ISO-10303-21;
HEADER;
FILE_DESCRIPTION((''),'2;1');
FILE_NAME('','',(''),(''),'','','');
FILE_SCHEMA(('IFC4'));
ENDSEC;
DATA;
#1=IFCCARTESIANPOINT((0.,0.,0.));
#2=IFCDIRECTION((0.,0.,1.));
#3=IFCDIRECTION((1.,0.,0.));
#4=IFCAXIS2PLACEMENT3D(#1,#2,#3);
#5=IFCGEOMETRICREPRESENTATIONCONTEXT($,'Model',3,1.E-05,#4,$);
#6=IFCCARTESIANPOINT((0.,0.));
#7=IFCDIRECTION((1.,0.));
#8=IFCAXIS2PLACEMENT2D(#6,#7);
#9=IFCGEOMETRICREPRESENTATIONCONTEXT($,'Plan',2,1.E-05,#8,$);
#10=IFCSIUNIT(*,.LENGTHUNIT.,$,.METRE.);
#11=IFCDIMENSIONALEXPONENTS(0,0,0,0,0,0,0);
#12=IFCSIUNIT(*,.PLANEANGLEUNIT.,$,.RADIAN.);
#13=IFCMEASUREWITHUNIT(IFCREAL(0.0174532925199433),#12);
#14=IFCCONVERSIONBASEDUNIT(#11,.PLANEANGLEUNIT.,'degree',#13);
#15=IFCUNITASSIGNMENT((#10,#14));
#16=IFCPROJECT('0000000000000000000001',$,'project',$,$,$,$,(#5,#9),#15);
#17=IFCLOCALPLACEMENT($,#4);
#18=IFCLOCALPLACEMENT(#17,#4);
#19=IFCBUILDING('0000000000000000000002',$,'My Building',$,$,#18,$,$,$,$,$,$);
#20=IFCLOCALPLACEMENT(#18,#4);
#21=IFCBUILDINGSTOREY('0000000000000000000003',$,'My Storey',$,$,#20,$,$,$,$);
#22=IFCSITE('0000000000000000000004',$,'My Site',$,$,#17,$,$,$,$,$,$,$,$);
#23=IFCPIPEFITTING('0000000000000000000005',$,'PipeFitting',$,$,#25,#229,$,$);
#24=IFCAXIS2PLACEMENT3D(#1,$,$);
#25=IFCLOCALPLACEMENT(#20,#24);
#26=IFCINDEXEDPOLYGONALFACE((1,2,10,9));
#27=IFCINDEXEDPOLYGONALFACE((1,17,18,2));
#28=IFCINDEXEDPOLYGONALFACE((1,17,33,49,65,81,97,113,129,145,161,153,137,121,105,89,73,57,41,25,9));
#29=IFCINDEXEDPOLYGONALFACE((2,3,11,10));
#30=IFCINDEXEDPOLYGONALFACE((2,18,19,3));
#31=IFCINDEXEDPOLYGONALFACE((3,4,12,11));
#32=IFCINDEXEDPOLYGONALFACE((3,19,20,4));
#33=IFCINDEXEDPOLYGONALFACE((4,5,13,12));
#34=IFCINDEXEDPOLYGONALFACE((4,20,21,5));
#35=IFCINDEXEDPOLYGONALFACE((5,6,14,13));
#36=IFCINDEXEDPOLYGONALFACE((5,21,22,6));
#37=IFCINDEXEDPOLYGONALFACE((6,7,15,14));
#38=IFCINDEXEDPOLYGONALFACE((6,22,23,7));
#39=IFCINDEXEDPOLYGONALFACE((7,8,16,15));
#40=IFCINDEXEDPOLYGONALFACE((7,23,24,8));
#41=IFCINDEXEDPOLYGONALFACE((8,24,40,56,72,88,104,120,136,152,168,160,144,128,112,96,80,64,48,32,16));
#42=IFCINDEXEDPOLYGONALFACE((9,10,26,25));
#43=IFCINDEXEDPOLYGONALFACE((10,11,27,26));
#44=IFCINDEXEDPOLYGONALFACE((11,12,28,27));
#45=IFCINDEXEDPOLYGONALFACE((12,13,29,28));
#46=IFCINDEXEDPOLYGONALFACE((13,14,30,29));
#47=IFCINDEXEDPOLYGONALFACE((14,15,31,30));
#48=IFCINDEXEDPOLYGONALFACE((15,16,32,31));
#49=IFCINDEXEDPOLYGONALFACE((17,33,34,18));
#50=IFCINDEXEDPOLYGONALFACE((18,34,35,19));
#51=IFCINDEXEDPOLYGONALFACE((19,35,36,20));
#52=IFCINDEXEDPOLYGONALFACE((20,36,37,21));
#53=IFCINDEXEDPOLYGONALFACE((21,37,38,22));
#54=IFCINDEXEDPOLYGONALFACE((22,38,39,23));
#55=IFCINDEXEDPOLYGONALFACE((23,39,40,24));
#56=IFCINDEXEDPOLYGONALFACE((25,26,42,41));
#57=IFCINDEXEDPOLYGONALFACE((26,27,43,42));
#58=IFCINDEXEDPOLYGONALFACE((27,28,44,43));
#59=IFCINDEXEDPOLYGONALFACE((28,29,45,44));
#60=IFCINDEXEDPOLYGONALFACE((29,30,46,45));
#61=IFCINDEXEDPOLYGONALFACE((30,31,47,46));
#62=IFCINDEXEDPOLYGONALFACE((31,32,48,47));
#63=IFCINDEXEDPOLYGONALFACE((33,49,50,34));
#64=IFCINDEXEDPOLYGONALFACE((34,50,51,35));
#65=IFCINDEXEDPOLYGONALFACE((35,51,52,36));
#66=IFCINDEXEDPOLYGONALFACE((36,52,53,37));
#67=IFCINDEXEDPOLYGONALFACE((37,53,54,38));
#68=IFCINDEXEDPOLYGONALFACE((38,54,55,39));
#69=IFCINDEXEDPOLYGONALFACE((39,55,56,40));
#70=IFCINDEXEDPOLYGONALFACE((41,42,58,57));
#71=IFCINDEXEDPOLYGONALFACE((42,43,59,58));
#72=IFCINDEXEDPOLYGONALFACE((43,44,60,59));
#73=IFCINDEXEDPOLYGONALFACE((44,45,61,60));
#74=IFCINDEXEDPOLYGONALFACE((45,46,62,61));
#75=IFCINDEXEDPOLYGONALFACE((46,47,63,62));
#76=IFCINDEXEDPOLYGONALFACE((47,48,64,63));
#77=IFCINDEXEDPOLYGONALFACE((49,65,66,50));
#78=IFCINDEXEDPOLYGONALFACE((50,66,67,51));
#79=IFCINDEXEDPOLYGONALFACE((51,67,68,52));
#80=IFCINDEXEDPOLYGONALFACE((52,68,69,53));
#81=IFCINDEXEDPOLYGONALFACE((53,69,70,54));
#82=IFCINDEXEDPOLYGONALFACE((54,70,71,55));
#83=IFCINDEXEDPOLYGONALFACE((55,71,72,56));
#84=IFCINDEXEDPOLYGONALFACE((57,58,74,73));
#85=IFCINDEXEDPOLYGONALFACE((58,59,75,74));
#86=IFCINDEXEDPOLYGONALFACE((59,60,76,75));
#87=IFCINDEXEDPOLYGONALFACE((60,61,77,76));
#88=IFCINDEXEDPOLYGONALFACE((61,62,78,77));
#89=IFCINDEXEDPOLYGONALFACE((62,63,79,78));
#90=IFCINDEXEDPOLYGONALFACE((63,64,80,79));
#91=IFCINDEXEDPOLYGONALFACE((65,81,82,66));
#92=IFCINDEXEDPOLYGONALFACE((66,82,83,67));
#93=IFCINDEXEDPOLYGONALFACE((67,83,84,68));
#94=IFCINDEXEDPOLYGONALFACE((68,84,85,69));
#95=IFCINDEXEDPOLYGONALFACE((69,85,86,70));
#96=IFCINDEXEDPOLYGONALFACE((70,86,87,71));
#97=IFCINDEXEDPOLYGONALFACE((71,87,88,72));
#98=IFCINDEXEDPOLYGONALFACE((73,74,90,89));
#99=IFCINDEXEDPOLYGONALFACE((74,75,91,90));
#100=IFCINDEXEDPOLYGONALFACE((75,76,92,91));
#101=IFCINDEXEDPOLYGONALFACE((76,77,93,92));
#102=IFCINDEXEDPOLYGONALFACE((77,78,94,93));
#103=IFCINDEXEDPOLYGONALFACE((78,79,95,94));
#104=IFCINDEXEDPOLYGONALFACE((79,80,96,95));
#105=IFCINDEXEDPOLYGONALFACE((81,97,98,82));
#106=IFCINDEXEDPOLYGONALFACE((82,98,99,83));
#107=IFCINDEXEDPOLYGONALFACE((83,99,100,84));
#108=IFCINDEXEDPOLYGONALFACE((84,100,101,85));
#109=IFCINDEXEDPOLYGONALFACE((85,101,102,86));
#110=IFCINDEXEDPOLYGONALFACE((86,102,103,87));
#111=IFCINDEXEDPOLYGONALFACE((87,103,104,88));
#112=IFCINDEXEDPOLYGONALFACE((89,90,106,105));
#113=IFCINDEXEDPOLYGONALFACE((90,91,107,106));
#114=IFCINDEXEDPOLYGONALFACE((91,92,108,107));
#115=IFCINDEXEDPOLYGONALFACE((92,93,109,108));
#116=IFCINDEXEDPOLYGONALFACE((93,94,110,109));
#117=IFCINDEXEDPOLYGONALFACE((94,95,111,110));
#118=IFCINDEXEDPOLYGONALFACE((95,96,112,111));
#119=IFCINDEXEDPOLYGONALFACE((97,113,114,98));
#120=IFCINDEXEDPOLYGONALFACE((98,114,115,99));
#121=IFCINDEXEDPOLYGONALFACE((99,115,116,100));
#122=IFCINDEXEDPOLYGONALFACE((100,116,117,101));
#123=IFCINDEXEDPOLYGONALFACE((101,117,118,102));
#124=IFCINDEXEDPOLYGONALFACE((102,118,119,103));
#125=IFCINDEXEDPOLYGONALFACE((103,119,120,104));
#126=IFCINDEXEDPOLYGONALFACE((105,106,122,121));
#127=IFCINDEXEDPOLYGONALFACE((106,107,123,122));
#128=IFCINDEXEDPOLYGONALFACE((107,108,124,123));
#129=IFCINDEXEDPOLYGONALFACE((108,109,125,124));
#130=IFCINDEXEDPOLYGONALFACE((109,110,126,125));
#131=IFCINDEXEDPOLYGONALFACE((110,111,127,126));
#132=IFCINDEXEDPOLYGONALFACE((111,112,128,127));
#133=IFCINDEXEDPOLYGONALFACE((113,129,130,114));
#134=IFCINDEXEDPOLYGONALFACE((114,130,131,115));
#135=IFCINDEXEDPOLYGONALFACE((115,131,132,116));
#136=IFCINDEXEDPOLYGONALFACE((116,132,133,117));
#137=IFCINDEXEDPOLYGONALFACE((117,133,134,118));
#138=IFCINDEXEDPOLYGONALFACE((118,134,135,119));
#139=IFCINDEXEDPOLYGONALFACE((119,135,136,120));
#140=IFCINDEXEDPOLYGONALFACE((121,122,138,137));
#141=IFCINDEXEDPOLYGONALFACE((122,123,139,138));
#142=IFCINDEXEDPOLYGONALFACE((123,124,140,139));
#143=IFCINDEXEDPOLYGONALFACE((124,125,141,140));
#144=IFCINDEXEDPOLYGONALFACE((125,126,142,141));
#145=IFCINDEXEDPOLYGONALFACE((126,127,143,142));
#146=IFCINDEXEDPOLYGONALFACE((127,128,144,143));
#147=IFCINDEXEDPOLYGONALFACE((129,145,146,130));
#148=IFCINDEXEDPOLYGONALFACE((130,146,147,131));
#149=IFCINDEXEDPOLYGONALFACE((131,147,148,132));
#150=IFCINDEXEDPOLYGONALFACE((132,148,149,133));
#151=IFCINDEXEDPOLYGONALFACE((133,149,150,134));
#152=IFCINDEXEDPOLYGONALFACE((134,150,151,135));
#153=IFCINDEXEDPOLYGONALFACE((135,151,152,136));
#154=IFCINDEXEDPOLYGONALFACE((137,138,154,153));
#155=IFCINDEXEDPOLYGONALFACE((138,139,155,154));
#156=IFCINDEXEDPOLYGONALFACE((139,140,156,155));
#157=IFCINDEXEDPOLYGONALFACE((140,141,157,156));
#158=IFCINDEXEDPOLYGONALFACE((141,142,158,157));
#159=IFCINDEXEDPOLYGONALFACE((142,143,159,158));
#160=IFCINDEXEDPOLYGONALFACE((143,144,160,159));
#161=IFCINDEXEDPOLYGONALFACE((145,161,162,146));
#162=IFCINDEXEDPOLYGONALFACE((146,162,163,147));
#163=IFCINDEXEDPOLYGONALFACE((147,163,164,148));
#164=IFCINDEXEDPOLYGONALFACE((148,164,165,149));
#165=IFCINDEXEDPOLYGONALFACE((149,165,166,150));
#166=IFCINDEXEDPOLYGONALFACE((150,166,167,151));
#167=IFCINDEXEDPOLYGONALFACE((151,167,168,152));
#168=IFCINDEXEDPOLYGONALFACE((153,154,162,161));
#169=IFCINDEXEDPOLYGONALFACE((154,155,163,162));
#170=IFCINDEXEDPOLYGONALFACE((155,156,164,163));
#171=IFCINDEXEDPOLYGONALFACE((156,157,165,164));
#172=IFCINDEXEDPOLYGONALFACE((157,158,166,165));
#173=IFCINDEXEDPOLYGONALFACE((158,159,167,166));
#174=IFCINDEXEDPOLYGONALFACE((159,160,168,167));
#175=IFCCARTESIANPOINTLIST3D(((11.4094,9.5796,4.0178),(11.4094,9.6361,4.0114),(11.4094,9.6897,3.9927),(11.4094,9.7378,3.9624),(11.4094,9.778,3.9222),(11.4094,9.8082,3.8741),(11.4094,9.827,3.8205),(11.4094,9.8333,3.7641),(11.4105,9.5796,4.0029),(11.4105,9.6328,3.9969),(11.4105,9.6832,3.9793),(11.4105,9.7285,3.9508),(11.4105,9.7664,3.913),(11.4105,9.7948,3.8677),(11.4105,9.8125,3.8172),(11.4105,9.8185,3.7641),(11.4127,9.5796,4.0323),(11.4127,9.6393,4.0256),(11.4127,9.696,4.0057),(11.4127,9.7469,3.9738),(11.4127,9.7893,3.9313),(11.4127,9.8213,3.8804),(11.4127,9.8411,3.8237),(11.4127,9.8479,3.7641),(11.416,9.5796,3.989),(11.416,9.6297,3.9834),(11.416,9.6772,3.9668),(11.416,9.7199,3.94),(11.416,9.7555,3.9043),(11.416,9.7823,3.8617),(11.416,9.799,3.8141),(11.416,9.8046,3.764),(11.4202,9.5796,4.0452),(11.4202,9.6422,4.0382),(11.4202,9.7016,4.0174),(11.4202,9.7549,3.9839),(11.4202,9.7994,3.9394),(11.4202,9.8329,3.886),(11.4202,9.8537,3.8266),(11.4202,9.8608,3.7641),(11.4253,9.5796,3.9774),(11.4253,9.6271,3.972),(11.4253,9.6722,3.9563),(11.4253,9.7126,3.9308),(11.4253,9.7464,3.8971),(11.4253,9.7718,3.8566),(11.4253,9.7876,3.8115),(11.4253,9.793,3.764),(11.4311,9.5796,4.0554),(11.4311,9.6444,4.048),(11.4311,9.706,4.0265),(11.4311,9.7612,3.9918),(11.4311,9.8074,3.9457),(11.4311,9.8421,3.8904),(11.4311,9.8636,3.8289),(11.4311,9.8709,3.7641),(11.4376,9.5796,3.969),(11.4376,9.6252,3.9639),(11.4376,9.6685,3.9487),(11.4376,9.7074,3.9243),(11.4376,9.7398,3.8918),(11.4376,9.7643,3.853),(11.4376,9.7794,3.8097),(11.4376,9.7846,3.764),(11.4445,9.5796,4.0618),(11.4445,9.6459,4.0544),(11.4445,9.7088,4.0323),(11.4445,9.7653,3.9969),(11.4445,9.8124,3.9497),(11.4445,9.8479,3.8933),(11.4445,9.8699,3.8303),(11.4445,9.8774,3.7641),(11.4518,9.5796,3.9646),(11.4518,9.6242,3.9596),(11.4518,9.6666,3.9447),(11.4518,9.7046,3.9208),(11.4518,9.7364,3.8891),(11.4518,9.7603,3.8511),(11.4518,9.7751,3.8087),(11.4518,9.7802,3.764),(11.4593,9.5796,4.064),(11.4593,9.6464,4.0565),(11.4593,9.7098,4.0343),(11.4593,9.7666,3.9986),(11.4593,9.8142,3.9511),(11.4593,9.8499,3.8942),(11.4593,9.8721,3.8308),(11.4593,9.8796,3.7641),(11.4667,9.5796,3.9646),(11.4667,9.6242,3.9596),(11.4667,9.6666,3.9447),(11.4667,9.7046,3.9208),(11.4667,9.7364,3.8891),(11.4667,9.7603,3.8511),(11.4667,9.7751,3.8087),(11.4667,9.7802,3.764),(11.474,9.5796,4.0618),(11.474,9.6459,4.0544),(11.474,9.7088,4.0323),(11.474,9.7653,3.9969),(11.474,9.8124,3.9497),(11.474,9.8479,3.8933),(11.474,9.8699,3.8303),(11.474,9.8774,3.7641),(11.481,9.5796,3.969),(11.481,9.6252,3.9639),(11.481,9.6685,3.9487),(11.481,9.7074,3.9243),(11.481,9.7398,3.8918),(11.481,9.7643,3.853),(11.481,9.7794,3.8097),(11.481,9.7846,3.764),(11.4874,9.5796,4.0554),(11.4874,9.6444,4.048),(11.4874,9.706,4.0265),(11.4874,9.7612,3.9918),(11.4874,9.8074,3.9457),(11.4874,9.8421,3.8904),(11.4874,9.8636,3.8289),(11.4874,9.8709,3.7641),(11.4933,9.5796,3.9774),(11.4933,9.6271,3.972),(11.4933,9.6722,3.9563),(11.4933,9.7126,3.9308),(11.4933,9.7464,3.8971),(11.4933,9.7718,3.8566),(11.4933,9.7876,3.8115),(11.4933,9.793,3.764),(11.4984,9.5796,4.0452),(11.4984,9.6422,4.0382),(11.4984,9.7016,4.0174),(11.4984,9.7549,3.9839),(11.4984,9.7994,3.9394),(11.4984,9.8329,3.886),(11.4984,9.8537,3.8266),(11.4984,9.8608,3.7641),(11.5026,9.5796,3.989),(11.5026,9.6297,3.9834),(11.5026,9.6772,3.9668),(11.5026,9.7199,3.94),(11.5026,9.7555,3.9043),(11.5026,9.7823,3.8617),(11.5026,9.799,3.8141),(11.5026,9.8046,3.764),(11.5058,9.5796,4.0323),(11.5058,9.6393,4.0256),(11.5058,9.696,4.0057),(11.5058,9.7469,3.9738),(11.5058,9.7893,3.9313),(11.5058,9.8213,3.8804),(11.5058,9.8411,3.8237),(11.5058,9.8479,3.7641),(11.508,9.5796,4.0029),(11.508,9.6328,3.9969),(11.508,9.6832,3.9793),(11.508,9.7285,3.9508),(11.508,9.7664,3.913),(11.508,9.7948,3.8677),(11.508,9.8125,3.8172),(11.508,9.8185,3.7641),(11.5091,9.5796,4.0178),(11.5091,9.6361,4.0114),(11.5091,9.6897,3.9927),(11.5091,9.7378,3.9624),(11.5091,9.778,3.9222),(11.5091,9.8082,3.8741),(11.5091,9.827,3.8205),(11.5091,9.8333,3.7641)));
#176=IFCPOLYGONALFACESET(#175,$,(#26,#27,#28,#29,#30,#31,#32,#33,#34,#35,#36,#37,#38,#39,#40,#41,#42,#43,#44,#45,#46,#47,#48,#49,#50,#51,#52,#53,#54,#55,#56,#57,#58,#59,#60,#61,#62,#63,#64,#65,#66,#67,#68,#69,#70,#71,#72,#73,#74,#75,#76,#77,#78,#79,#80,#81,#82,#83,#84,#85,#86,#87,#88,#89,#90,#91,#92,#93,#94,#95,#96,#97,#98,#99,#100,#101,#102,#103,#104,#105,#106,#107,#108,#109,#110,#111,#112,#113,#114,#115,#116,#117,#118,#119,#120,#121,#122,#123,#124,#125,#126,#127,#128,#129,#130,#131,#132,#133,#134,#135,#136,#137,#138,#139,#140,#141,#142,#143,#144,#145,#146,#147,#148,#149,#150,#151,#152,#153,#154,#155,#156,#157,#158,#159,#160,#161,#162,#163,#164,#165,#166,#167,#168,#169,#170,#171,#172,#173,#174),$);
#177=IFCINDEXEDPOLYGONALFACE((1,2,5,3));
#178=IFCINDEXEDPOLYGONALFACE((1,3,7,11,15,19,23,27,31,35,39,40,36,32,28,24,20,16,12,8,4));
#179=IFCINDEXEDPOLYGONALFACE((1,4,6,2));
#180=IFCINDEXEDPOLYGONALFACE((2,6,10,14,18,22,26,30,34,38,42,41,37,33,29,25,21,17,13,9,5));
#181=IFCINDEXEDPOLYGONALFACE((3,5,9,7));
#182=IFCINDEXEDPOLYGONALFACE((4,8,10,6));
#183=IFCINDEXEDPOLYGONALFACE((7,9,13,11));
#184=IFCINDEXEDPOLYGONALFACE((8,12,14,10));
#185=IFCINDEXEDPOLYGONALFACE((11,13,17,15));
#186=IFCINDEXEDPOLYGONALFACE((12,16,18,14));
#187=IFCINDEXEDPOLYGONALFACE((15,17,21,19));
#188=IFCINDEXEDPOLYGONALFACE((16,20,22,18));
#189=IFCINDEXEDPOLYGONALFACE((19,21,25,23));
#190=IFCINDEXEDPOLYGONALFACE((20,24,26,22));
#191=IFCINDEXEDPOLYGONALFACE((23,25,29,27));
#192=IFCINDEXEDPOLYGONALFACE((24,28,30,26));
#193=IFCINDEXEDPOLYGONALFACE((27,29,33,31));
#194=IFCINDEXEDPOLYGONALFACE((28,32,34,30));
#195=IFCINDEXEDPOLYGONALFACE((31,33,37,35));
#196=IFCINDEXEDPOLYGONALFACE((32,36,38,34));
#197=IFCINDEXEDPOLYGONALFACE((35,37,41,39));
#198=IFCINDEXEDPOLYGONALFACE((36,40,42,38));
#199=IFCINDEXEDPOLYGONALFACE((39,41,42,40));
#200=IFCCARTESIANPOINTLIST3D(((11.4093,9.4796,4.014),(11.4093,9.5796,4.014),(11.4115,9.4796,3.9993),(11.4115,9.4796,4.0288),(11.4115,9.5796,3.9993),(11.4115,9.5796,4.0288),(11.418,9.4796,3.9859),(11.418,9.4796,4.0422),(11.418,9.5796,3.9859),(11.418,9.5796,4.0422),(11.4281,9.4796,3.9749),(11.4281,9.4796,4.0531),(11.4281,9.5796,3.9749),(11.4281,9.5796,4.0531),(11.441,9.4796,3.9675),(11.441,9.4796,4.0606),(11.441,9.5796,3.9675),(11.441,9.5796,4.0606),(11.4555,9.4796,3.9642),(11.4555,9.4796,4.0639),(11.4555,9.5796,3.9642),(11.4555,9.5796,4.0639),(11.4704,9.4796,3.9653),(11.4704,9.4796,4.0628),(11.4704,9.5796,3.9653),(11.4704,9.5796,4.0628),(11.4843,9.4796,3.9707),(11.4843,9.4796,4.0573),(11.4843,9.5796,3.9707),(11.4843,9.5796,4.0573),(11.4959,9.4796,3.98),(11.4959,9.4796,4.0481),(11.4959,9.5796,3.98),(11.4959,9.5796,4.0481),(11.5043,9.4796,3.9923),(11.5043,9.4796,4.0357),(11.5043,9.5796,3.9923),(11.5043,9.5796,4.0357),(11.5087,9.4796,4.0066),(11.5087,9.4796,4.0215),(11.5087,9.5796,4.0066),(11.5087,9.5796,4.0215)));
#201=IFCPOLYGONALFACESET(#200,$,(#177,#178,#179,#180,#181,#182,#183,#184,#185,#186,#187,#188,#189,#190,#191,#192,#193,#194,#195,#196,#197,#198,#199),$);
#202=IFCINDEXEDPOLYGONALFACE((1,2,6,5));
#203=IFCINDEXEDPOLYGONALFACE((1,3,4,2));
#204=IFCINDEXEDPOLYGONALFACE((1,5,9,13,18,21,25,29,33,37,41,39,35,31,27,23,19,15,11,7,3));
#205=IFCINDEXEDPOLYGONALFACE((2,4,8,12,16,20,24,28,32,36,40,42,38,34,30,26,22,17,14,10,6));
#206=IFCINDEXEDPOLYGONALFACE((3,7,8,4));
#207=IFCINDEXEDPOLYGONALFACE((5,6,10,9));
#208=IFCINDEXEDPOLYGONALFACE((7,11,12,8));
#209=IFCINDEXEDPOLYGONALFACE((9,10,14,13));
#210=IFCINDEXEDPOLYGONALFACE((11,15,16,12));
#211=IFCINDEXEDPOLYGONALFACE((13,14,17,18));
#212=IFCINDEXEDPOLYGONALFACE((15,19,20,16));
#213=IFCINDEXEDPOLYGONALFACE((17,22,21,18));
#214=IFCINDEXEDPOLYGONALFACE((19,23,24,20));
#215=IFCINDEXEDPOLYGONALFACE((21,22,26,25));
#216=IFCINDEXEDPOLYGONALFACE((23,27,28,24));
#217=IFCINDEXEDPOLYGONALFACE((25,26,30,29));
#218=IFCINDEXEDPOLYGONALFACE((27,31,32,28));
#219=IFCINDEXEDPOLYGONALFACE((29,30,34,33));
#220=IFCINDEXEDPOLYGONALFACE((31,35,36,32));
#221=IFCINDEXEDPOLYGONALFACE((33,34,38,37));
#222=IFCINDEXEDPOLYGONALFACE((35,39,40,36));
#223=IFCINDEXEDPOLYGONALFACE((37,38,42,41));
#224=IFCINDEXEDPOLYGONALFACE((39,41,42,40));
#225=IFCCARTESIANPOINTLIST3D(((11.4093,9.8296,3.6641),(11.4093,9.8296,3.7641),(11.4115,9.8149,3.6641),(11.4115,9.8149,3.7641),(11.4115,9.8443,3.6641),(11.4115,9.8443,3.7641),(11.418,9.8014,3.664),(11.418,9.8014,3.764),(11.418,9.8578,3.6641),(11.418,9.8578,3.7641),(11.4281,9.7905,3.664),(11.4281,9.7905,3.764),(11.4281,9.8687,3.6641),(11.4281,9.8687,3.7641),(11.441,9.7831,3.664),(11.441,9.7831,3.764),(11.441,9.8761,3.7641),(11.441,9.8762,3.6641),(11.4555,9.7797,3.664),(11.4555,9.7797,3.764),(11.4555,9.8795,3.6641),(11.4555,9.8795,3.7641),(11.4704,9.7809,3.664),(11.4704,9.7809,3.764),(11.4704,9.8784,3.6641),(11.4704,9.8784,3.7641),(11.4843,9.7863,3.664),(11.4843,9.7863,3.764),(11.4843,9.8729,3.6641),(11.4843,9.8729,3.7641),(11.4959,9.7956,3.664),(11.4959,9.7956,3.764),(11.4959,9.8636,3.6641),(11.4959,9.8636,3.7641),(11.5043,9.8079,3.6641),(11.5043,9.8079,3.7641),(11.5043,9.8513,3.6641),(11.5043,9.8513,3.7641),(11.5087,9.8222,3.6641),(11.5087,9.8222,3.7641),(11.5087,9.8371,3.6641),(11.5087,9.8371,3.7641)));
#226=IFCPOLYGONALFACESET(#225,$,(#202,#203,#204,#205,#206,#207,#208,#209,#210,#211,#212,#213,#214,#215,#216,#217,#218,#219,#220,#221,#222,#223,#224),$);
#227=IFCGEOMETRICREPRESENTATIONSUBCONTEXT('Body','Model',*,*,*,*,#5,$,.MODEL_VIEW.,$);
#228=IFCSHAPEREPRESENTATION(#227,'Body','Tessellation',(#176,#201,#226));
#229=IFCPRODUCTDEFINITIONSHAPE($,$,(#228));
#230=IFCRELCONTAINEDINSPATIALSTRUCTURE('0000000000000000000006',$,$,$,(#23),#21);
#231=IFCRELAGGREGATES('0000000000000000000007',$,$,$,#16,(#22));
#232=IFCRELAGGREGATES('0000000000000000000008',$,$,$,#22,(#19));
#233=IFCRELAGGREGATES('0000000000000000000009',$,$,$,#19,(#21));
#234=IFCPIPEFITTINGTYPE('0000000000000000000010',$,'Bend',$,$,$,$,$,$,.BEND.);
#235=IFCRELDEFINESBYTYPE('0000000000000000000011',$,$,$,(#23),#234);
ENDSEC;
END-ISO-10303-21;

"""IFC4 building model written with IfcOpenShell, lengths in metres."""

from ifc_helpers import new_model, entity, si_unit, converted_unit, frame, origin_with_axes, origin_2d_with_axis, place, context, subcontext, project, spatial, circle, extrude, source, transform, mapped, type_object, type_shapes, element, save


model = new_model("IFC4")

# Units and contexts
model_context = context("Model", 3, precision=1e-05, world=origin_with_axes())
plan_context = context("Plan", 2, precision=1e-05, world=origin_2d_with_axis())
body_context_1 = subcontext(model_context, "Body", "Model", "MODEL_VIEW")
ifc_project = project(units=[si_unit("LENGTHUNIT", "METRE"), converted_unit("PLANEANGLEUNIT", "degree", entity("IfcReal", 0.0174532925199433), si_unit("PLANEANGLEUNIT", "RADIAN"), dimensions=[0, 0, 0, 0, 0, 0, 0])], contexts=[model_context, plan_context])

# Site, building, storey
site_placement = place(None, origin_with_axes())
site = spatial("IfcSite", under=ifc_project, at=site_placement, Name="My Site")
building_placement = place(site_placement, origin_with_axes())
building = spatial("IfcBuilding", under=site, at=building_placement, Name="My Building")
storey_placement = place(building_placement, origin_with_axes())
storey = spatial("IfcBuildingStorey", under=building, at=storey_placement, Name="My Storey")

# Pipe fitting
pipe_fitting_type_1 = type_object("IfcPipeFittingType", Name="Bend", PredefinedType="BEND")
shared_shape_1 = source(origin_with_axes(), body_context_1, "Body", "SolidModel", [
    entity("IfcSweptDiskSolid", entity("IfcIndexedPolyCurve", entity("IfcCartesianPointList3D", [[0.0, 0.0, 0.1], [0.0, -0.0732, 0.2768], [0.0, -0.25, 0.35]]), [entity("IfcArcIndex", [1, 2, 3])]), 0.05),
    extrude(circle(Radius=0.05), origin_with_axes(), (0.0, 0.0, 1.0), 0.1),
    extrude(circle(Radius=0.05), frame((0.0, -0.25, 0.35), z_axis=(0.0, -1.0, 0.000038), x_axis=(1.0, 0.0, 0.0)), (0.0, 0.0, 1.0), 0.1),
])
type_shapes(pipe_fitting_type_1, [shared_shape_1])
for number, where, z_axis, x_axis, name in (
    (1, (11.4593, 9.4796, 4.014), (0.0, 1.0, 0.0), (-1.0, 0.0, 0.0), "PipeFitting"),
):
    element("IfcPipeFitting", number, at=place(storey_placement, frame(where, z_axis=z_axis, x_axis=x_axis)), inside=storey, type_object=pipe_fitting_type_1, Name=name, context=body_context_1, shape_type="MappedRepresentation", body=[
        mapped(shared_shape_1, transform((0.0, 0.0, 0.0), x_axis=(1.0, 0.0, 0.0), y_axis=(0.0, 1.0, 0.0), z_axis=(0.0, 0.0, 1.0), scale=1.0)),
    ])

save(model, "model.ifc")
